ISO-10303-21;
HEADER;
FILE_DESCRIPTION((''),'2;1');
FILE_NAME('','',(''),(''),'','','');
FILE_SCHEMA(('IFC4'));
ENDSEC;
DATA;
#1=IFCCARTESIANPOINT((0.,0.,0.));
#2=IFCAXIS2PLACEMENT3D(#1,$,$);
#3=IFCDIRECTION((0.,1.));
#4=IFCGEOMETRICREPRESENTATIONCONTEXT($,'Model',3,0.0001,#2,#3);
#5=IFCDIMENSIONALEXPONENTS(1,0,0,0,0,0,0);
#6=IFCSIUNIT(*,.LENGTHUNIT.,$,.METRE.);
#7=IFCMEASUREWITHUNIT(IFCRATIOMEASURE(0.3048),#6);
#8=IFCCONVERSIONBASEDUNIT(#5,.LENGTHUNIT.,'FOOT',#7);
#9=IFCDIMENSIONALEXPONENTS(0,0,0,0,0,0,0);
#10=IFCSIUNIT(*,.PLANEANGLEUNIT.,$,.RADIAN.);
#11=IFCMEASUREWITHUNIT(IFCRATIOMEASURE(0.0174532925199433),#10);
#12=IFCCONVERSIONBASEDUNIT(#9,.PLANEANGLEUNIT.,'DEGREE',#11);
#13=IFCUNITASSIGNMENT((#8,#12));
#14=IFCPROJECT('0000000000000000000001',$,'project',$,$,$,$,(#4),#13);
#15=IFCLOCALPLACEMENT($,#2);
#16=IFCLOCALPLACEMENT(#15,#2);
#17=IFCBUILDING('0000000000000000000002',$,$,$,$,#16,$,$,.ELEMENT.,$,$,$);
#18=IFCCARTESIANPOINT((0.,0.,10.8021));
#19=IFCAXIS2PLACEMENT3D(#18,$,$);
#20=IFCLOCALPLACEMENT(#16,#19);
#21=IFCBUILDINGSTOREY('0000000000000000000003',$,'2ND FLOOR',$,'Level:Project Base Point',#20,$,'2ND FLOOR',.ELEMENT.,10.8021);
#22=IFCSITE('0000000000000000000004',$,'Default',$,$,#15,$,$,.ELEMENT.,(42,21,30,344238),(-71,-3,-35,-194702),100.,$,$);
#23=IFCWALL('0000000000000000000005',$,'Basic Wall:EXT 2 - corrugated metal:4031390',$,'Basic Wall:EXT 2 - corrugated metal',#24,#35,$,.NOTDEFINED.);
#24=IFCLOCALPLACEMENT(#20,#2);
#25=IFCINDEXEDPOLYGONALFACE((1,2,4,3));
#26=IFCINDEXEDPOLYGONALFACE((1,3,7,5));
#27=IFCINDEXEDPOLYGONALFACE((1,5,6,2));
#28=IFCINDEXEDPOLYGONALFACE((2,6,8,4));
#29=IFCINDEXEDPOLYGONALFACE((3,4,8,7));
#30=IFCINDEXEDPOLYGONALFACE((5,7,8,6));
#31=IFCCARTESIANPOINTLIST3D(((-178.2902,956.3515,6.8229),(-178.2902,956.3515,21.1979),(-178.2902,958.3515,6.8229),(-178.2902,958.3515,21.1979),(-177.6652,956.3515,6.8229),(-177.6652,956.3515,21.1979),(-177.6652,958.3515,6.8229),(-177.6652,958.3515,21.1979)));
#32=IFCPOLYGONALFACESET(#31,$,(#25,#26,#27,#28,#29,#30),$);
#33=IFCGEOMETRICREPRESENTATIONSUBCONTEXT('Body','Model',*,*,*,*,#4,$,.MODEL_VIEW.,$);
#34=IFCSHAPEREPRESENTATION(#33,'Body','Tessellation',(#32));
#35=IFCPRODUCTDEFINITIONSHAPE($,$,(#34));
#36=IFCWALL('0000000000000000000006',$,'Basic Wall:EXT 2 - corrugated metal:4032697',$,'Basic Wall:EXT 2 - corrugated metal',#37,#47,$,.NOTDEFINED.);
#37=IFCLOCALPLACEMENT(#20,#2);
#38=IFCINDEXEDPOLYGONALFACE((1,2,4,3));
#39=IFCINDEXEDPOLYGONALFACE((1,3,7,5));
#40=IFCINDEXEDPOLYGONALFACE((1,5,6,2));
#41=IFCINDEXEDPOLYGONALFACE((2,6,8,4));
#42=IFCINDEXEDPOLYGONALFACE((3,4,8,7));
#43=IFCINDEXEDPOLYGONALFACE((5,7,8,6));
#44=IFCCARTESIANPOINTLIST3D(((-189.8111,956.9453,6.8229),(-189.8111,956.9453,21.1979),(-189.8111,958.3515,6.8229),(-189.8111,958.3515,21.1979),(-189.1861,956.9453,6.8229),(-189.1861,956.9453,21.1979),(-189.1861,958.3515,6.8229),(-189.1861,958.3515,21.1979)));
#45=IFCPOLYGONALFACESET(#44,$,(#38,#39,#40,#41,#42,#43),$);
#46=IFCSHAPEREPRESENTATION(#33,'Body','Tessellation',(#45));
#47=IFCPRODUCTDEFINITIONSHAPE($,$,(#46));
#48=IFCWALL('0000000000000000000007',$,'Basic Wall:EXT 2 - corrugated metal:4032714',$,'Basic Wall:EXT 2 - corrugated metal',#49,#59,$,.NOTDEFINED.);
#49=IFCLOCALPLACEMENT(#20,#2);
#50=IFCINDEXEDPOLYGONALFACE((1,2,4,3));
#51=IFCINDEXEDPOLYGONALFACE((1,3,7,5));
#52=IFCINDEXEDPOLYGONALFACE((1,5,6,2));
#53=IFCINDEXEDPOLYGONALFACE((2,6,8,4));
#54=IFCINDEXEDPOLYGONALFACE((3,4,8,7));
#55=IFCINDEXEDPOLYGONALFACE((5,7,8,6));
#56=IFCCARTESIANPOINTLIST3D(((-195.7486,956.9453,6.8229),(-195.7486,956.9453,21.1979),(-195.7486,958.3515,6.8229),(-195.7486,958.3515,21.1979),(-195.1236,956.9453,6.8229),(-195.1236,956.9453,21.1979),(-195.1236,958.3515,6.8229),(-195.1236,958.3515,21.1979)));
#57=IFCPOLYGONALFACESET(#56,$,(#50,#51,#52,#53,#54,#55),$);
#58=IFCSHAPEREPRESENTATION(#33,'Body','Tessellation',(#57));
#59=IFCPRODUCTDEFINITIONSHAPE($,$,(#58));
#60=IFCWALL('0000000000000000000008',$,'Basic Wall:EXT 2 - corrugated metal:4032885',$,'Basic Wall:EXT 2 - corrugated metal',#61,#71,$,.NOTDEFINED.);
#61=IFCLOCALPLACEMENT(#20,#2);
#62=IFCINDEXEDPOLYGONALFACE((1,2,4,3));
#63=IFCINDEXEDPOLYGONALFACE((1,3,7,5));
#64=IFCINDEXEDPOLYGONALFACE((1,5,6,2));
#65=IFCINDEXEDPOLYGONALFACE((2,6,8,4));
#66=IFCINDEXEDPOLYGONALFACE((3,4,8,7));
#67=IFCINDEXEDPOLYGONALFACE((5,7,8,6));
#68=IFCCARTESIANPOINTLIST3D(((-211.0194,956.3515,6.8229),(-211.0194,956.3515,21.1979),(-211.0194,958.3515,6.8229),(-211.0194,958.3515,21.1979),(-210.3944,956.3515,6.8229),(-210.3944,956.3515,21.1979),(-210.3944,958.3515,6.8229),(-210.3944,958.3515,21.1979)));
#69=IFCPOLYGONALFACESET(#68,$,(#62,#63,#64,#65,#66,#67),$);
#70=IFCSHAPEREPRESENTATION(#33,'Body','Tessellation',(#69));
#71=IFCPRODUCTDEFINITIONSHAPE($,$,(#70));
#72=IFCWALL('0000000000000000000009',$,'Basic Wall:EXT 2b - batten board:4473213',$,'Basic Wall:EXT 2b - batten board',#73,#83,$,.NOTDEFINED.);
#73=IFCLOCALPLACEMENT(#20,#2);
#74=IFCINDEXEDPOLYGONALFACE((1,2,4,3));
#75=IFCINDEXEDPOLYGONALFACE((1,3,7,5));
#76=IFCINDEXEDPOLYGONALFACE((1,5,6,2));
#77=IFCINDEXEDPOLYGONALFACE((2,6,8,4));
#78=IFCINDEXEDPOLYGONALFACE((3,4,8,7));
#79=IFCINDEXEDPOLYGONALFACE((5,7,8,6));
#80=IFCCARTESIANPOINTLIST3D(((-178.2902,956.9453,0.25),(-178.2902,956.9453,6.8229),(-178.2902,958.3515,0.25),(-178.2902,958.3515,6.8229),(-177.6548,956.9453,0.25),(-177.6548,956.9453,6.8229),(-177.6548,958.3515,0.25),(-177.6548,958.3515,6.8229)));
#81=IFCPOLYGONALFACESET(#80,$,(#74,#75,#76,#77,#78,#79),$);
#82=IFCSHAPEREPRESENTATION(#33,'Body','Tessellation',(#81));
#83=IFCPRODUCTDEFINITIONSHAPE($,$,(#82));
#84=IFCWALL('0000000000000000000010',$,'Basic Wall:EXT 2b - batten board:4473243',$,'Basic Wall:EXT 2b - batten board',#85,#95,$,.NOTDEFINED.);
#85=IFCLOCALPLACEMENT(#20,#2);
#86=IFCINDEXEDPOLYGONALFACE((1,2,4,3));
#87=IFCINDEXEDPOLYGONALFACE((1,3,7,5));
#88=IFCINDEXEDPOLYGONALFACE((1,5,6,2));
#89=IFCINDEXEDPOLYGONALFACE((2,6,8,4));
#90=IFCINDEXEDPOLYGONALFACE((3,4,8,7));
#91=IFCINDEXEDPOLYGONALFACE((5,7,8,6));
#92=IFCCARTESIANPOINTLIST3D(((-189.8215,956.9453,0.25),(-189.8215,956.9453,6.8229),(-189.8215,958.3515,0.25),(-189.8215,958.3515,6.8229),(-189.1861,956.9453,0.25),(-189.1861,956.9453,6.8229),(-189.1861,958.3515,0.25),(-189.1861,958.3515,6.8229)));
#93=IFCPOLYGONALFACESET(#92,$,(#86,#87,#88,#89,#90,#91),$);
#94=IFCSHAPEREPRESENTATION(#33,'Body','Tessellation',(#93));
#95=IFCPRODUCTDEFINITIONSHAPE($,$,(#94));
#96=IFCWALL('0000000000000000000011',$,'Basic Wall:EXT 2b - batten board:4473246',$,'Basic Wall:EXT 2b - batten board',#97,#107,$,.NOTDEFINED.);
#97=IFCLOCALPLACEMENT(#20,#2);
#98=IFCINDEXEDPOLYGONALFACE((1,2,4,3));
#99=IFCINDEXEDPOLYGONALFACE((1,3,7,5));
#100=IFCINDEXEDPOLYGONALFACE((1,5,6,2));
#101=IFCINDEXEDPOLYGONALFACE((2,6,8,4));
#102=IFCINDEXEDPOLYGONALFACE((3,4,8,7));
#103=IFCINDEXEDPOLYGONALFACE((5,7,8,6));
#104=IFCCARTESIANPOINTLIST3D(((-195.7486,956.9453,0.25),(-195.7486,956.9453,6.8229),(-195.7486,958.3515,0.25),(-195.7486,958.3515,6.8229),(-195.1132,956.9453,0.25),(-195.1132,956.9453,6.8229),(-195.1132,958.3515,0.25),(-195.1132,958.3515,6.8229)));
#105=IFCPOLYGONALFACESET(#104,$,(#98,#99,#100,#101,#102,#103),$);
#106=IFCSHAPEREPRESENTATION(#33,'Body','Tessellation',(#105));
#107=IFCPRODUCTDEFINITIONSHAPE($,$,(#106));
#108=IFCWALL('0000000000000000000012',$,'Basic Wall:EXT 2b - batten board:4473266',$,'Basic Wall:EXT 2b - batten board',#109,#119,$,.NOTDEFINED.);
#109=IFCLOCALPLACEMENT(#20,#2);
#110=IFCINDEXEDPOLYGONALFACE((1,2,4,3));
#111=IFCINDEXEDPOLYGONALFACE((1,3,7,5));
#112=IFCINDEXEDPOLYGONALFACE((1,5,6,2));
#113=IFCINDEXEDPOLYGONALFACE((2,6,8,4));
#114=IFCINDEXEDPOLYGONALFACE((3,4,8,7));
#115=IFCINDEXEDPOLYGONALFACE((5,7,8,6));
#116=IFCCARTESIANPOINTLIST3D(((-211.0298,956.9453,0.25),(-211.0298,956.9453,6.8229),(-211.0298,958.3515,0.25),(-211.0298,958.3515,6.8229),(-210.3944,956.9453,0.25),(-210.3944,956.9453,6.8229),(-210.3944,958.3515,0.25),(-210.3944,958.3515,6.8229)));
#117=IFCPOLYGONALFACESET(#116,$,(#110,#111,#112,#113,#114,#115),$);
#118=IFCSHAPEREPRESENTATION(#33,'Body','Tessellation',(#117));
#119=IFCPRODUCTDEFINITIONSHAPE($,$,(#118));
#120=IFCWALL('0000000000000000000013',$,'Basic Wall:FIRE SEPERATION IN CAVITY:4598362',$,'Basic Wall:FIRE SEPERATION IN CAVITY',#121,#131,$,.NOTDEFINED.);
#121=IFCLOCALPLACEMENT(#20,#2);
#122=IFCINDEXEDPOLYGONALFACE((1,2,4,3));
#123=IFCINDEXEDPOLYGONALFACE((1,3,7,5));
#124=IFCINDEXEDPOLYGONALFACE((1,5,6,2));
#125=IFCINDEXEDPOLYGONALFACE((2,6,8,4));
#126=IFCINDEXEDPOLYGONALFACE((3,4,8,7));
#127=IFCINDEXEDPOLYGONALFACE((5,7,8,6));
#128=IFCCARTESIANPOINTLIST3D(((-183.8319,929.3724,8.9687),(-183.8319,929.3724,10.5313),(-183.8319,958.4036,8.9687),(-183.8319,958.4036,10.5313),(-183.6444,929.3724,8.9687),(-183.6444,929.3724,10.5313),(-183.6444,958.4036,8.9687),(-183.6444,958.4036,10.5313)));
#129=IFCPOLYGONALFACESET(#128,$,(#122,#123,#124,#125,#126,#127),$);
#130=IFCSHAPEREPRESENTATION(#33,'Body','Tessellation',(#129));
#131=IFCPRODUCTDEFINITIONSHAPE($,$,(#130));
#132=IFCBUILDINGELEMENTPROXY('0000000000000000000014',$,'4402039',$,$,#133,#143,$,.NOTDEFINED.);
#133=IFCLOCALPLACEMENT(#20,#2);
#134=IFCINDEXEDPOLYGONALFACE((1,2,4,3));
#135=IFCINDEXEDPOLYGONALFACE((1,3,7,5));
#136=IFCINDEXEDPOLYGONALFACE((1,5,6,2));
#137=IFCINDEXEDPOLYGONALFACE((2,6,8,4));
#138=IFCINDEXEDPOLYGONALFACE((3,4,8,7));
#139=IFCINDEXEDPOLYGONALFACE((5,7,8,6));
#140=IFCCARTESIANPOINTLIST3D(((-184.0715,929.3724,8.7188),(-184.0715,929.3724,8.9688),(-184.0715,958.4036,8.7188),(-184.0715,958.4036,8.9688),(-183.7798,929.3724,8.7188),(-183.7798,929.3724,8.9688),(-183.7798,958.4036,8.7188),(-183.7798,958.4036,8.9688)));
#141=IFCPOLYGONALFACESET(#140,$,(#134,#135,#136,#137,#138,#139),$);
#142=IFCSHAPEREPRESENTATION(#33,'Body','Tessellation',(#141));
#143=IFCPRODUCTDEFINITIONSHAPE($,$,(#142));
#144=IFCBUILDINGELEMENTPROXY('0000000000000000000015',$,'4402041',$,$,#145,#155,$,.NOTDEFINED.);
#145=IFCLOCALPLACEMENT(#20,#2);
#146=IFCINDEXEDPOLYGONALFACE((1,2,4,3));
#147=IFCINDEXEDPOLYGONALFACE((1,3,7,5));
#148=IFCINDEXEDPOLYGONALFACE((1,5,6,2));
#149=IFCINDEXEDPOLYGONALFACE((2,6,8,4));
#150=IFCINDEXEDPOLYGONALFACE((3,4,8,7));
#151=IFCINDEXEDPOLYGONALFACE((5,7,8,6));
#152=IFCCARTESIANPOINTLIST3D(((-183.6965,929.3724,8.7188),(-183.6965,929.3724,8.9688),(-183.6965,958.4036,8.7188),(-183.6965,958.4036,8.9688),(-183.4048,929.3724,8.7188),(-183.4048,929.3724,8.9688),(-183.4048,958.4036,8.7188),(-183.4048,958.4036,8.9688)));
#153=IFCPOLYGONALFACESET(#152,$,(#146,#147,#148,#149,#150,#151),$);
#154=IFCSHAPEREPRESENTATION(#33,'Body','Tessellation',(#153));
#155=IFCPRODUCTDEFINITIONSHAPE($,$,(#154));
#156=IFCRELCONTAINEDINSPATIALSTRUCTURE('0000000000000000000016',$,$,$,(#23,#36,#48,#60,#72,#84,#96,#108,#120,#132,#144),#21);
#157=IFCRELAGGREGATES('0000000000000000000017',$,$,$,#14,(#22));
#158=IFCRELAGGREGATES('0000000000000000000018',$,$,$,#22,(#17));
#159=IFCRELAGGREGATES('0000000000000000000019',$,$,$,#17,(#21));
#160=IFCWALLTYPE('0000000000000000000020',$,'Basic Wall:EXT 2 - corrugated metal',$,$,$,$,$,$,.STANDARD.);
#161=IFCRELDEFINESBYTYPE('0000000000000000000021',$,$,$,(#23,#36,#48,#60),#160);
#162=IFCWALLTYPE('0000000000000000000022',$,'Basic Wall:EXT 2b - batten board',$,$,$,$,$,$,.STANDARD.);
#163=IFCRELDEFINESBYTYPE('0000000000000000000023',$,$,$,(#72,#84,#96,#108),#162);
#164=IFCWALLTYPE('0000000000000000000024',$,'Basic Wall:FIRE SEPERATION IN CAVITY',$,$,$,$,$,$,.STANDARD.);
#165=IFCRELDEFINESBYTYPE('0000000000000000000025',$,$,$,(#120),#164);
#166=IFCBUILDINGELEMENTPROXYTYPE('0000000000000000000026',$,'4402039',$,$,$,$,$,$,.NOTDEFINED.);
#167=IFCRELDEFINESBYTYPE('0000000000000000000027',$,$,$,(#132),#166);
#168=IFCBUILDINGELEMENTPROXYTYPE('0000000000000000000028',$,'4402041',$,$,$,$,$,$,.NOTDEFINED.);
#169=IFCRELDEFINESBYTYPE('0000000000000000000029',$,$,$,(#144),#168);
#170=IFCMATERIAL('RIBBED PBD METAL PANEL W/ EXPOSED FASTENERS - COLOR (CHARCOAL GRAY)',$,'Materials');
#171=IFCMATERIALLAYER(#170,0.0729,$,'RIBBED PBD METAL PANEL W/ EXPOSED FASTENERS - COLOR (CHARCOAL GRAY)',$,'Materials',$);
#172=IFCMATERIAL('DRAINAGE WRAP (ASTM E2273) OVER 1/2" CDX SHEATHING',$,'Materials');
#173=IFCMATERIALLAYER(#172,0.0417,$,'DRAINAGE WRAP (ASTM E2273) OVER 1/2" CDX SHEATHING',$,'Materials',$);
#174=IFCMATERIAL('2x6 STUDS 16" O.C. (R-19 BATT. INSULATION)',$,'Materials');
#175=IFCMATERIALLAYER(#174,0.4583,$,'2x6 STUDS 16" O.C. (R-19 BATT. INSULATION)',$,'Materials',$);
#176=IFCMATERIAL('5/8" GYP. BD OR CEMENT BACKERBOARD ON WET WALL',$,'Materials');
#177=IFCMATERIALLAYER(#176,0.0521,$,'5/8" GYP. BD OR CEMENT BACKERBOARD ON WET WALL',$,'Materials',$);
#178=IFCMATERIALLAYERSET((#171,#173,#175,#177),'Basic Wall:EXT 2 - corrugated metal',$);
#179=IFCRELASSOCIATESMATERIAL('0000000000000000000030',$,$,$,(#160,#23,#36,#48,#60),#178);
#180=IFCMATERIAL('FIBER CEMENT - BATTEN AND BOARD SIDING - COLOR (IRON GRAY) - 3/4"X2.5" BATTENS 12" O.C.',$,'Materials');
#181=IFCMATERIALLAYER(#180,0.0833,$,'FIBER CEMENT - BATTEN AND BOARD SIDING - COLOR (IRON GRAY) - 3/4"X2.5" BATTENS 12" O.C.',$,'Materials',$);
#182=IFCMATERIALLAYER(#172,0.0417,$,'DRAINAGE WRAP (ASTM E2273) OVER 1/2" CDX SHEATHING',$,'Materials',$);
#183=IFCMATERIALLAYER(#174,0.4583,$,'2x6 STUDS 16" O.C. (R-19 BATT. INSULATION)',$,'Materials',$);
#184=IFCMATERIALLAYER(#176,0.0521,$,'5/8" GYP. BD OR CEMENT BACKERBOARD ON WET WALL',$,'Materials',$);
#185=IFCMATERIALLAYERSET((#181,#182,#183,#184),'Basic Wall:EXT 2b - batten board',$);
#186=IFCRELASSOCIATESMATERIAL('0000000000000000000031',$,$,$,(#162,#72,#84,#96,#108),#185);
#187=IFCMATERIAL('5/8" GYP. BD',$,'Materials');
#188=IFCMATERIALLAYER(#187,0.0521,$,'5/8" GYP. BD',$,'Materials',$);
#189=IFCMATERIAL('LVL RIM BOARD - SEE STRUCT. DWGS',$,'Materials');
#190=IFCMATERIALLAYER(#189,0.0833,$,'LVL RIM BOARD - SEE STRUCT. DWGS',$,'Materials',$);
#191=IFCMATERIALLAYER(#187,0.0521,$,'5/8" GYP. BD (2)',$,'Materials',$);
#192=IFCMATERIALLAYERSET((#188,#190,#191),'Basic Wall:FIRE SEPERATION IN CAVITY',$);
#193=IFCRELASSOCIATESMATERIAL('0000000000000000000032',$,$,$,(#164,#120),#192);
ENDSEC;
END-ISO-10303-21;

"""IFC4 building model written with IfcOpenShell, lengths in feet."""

from ifc_helpers import new_model, entity, si_unit, converted_unit, direction, frame, frame_2d, origin, origin_2d_with_axis, place, context, subcontext, project, spatial, rectangle, extrude, material, layer, layer_set, layer_usage, type_object, element, save


model = new_model("IFC4")

# Units and contexts
model_context = context("Model", 3, precision=0.0001, world=origin(), true_north=direction((0.0, 1.0)))
body_context = subcontext(model_context, "Body", "Model", "MODEL_VIEW")
ifc_project = project(units=[converted_unit("LENGTHUNIT", "FOOT", entity("IfcRatioMeasure", 0.3048), si_unit("LENGTHUNIT", "METRE"), dimensions=[1, 0, 0, 0, 0, 0, 0]), converted_unit("PLANEANGLEUNIT", "DEGREE", entity("IfcRatioMeasure", 0.0174532925199433), si_unit("PLANEANGLEUNIT", "RADIAN"), dimensions=[0, 0, 0, 0, 0, 0, 0])], contexts=[model_context])

# Site, building, storey
site_placement = place(None, origin())
site = spatial("IfcSite", under=ifc_project, at=site_placement, Name="Default", CompositionType="ELEMENT", RefLatitude=(42, 21, 30, 344238), RefLongitude=(-71, -3, -35, -194702), RefElevation=100.0)
building_placement = place(site_placement, origin())
building = spatial("IfcBuilding", under=site, at=building_placement, CompositionType="ELEMENT")
storey_placement = place(building_placement, frame((0.0, 0.0, 10.8021)))
storey = spatial("IfcBuildingStorey", under=building, at=storey_placement, Name="2ND FLOOR", ObjectType="Level:Project Base Point", LongName="2ND FLOOR", CompositionType="ELEMENT", Elevation=10.8021)

# Walls
ifc_material_1 = material(Name="RIBBED PBD METAL PANEL W/ EXPOSED FASTENERS - COLOR (CHARCOAL GRAY)", Category="Materials")
ifc_layer_1 = layer(ifc_material_1, 0.0729, Name="RIBBED PBD METAL PANEL W/ EXPOSED FASTENERS - COLOR (CHARCOAL GRAY)", Category="Materials")
ifc_material_2 = material(Name="DRAINAGE WRAP (ASTM E2273) OVER 1/2\" CDX SHEATHING", Category="Materials")
ifc_layer_2 = layer(ifc_material_2, 0.0417, Name="DRAINAGE WRAP (ASTM E2273) OVER 1/2\" CDX SHEATHING", Category="Materials")
ifc_material_3 = material(Name="2x6 STUDS 16\" O.C. (R-19 BATT. INSULATION)", Category="Materials")
ifc_layer_3 = layer(ifc_material_3, 0.4583, Name="2x6 STUDS 16\" O.C. (R-19 BATT. INSULATION)", Category="Materials")
ifc_material_4 = material(Name="5/8\" GYP. BD OR CEMENT BACKERBOARD ON WET WALL", Category="Materials")
ifc_layer_4 = layer(ifc_material_4, 0.0521, Name="5/8\" GYP. BD OR CEMENT BACKERBOARD ON WET WALL", Category="Materials")
ifc_layer_set_1 = layer_set([ifc_layer_1, ifc_layer_2, ifc_layer_3, ifc_layer_4], Name="Basic Wall:EXT 2 - corrugated metal")
ifc_layer_usage_1 = layer_usage(ifc_layer_set_1, "AXIS2", "NEGATIVE", 0.3125)
wall_type_1 = type_object("IfcWallType", Name="Basic Wall:EXT 2 - corrugated metal", PredefinedType="STANDARD", material=ifc_layer_set_1)
wall_1_placement = place(storey_placement, frame((-177.9777, 958.3515, 6.8229), z_axis=(0.0, 0.0, 1.0), x_axis=(0.0, -1.0, 0.0)))
element("IfcWall", 1, at=wall_1_placement, inside=storey, type_object=wall_type_1, material=ifc_layer_usage_1, Name="Basic Wall:EXT 2 - corrugated metal:4031390", ObjectType="Basic Wall:EXT 2 - corrugated metal", PredefinedType="NOTDEFINED", context=body_context, shape_type="SweptSolid", body=[
    extrude(rectangle(XDim=2.0, YDim=0.625, at=frame_2d((1.0, 0.0), x_axis=(-1.0, 0.0))), origin(), (0.0, 0.0, 1.0), 14.375),
])
ifc_layer_usage_2 = layer_usage(ifc_layer_set_1, "AXIS2", "POSITIVE", -0.3125)
wall_2_placement = place(storey_placement, frame((-189.4986, 958.3515, 6.8229), z_axis=(0.0, 0.0, 1.0), x_axis=(0.0, -1.0, 0.0)))
element("IfcWall", 2, at=wall_2_placement, inside=storey, type_object=wall_type_1, material=ifc_layer_usage_2, Name="Basic Wall:EXT 2 - corrugated metal:4032697", ObjectType="Basic Wall:EXT 2 - corrugated metal", PredefinedType="NOTDEFINED", context=body_context, shape_type="SweptSolid", body=[
    extrude(rectangle(XDim=1.4063, YDim=0.625, at=frame_2d((0.7031, 0.0), x_axis=(-1.0, 0.0))), origin(), (0.0, 0.0, 1.0), 14.375),
])
ifc_layer_usage_3 = layer_usage(ifc_layer_set_1, "AXIS2", "NEGATIVE", 0.3125)
wall_3_placement = place(storey_placement, frame((-195.4361, 958.3515, 6.8229), z_axis=(0.0, 0.0, 1.0), x_axis=(0.0, -1.0, 0.0)))
element("IfcWall", 3, at=wall_3_placement, inside=storey, type_object=wall_type_1, material=ifc_layer_usage_3, Name="Basic Wall:EXT 2 - corrugated metal:4032714", ObjectType="Basic Wall:EXT 2 - corrugated metal", PredefinedType="NOTDEFINED", context=body_context, shape_type="SweptSolid", body=[
    extrude(rectangle(XDim=1.4062, YDim=0.625, at=frame_2d((0.7031, 0.0), x_axis=(-1.0, 0.0))), origin(), (0.0, 0.0, 1.0), 14.375),
])
ifc_layer_usage_4 = layer_usage(ifc_layer_set_1, "AXIS2", "POSITIVE", -0.3125)
wall_4_placement = place(storey_placement, frame((-210.7069, 958.3515, 6.8229), z_axis=(0.0, 0.0, 1.0), x_axis=(0.0, -1.0, 0.0)))
element("IfcWall", 4, at=wall_4_placement, inside=storey, type_object=wall_type_1, material=ifc_layer_usage_4, Name="Basic Wall:EXT 2 - corrugated metal:4032885", ObjectType="Basic Wall:EXT 2 - corrugated metal", PredefinedType="NOTDEFINED", context=body_context, shape_type="SweptSolid", body=[
    extrude(rectangle(XDim=2.0, YDim=0.625, at=frame_2d((1.0, 0.0), x_axis=(-1.0, 0.0))), origin(), (0.0, 0.0, 1.0), 14.375),
])
ifc_material_5 = material(Name="FIBER CEMENT - BATTEN AND BOARD SIDING - COLOR (IRON GRAY) - 3/4\"X2.5\" BATTENS 12\" O.C.", Category="Materials")
ifc_layer_5 = layer(ifc_material_5, 0.0833, Name="FIBER CEMENT - BATTEN AND BOARD SIDING - COLOR (IRON GRAY) - 3/4\"X2.5\" BATTENS 12\" O.C.", Category="Materials")
ifc_layer_6 = layer(ifc_material_2, 0.0417, Name="DRAINAGE WRAP (ASTM E2273) OVER 1/2\" CDX SHEATHING", Category="Materials")
ifc_layer_7 = layer(ifc_material_3, 0.4583, Name="2x6 STUDS 16\" O.C. (R-19 BATT. INSULATION)", Category="Materials")
ifc_layer_8 = layer(ifc_material_4, 0.0521, Name="5/8\" GYP. BD OR CEMENT BACKERBOARD ON WET WALL", Category="Materials")
ifc_layer_set_2 = layer_set([ifc_layer_5, ifc_layer_6, ifc_layer_7, ifc_layer_8], Name="Basic Wall:EXT 2b - batten board")
ifc_layer_usage_5 = layer_usage(ifc_layer_set_2, "AXIS2", "NEGATIVE", 0.3177)
wall_type_2 = type_object("IfcWallType", Name="Basic Wall:EXT 2b - batten board", PredefinedType="STANDARD", material=ifc_layer_set_2)
wall_5_placement = place(storey_placement, frame((-177.9725, 958.3515, 0.25), z_axis=(0.0, 0.0, 1.0), x_axis=(0.0, -1.0, 0.0)))
element("IfcWall", 5, at=wall_5_placement, inside=storey, type_object=wall_type_2, material=ifc_layer_usage_5, Name="Basic Wall:EXT 2b - batten board:4473213", ObjectType="Basic Wall:EXT 2b - batten board", PredefinedType="NOTDEFINED", context=body_context, shape_type="SweptSolid", body=[
    extrude(rectangle(XDim=1.4063, YDim=0.6354, at=frame_2d((0.7031, 0.0), x_axis=(-1.0, 0.0))), origin(), (0.0, 0.0, 1.0), 6.5729),
])
ifc_layer_usage_6 = layer_usage(ifc_layer_set_2, "AXIS2", "POSITIVE", -0.3177)
wall_6_placement = place(storey_placement, frame((-189.5038, 958.3515, 0.25), z_axis=(0.0, 0.0, 1.0), x_axis=(0.0, -1.0, 0.0)))
element("IfcWall", 6, at=wall_6_placement, inside=storey, type_object=wall_type_2, material=ifc_layer_usage_6, Name="Basic Wall:EXT 2b - batten board:4473243", ObjectType="Basic Wall:EXT 2b - batten board", PredefinedType="NOTDEFINED", context=body_context, shape_type="SweptSolid", body=[
    extrude(rectangle(XDim=1.4063, YDim=0.6354, at=frame_2d((0.7031, 0.0), x_axis=(-1.0, 0.0))), origin(), (0.0, 0.0, 1.0), 6.5729),
])
ifc_layer_usage_7 = layer_usage(ifc_layer_set_2, "AXIS2", "NEGATIVE", 0.3177)
wall_7_placement = place(storey_placement, frame((-195.4309, 958.3515, 0.25), z_axis=(0.0, 0.0, 1.0), x_axis=(0.0, -1.0, 0.0)))
element("IfcWall", 7, at=wall_7_placement, inside=storey, type_object=wall_type_2, material=ifc_layer_usage_7, Name="Basic Wall:EXT 2b - batten board:4473246", ObjectType="Basic Wall:EXT 2b - batten board", PredefinedType="NOTDEFINED", context=body_context, shape_type="SweptSolid", body=[
    extrude(rectangle(XDim=1.4062, YDim=0.6354, at=frame_2d((0.7031, 0.0), x_axis=(-1.0, 0.0))), origin(), (0.0, 0.0, 1.0), 6.5729),
])
ifc_layer_usage_8 = layer_usage(ifc_layer_set_2, "AXIS2", "POSITIVE", -0.3177)
wall_8_placement = place(storey_placement, frame((-210.7121, 958.3515, 0.25), z_axis=(0.0, 0.0, 1.0), x_axis=(0.0, -1.0, 0.0)))
element("IfcWall", 8, at=wall_8_placement, inside=storey, type_object=wall_type_2, material=ifc_layer_usage_8, Name="Basic Wall:EXT 2b - batten board:4473266", ObjectType="Basic Wall:EXT 2b - batten board", PredefinedType="NOTDEFINED", context=body_context, shape_type="SweptSolid", body=[
    extrude(rectangle(XDim=1.4062, YDim=0.6354, at=frame_2d((0.7031, 0.0), x_axis=(-1.0, 0.0))), origin(), (0.0, 0.0, 1.0), 6.5729),
])
ifc_material_6 = material(Name="5/8\" GYP. BD", Category="Materials")
ifc_layer_9 = layer(ifc_material_6, 0.0521, Name="5/8\" GYP. BD", Category="Materials")
ifc_material_7 = material(Name="LVL RIM BOARD - SEE STRUCT. DWGS", Category="Materials")
ifc_layer_10 = layer(ifc_material_7, 0.0833, Name="LVL RIM BOARD - SEE STRUCT. DWGS", Category="Materials")
ifc_layer_11 = layer(ifc_material_6, 0.0521, Name="5/8\" GYP. BD (2)", Category="Materials")
ifc_layer_set_3 = layer_set([ifc_layer_9, ifc_layer_10, ifc_layer_11], Name="Basic Wall:FIRE SEPERATION IN CAVITY")
ifc_layer_usage_9 = layer_usage(ifc_layer_set_3, "AXIS2", "POSITIVE", -0.0938)
wall_type_3 = type_object("IfcWallType", Name="Basic Wall:FIRE SEPERATION IN CAVITY", PredefinedType="STANDARD", material=ifc_layer_set_3)
wall_9_placement = place(storey_placement, frame((-183.7382, 929.3724, 8.9687), z_axis=(0.0, 0.0, 1.0), x_axis=(0.0, 1.0, 0.0)))
element("IfcWall", 9, at=wall_9_placement, inside=storey, type_object=wall_type_3, material=ifc_layer_usage_9, Name="Basic Wall:FIRE SEPERATION IN CAVITY:4598362", ObjectType="Basic Wall:FIRE SEPERATION IN CAVITY", PredefinedType="NOTDEFINED", context=body_context, shape_type="SweptSolid", body=[
    extrude(rectangle(XDim=29.0313, YDim=0.1875, at=frame_2d((14.5156, 0.0), x_axis=(-1.0, 0.0))), origin(), (0.0, 0.0, 1.0), 1.5625),
])

# Building element proxies
building_element_proxy_type_1 = type_object("IfcBuildingElementProxyType", Name="4402039", PredefinedType="NOTDEFINED")
proxy_1_placement = place(storey_placement, frame((-184.0715, 929.3724, 8.7188)))
element("IfcBuildingElementProxy", 10, at=proxy_1_placement, inside=storey, type_object=building_element_proxy_type_1, Name="4402039", PredefinedType="NOTDEFINED", context=body_context, shape_type="SweptSolid", body=[
    extrude(rectangle(XDim=29.0313, YDim=0.2917, at=origin_2d_with_axis()), frame((0.1458, 14.5156, 0.0), z_axis=(0.0, 0.0, 1.0), x_axis=(0.0, 1.0, 0.0)), (0.0, 0.0, 1.0), 0.25),
])
building_element_proxy_type_2 = type_object("IfcBuildingElementProxyType", Name="4402041", PredefinedType="NOTDEFINED")
proxy_2_placement = place(storey_placement, frame((-183.6965, 929.3724, 8.7188)))
element("IfcBuildingElementProxy", 11, at=proxy_2_placement, inside=storey, type_object=building_element_proxy_type_2, Name="4402041", PredefinedType="NOTDEFINED", context=body_context, shape_type="SweptSolid", body=[
    extrude(rectangle(XDim=29.0313, YDim=0.2917, at=origin_2d_with_axis()), frame((0.1458, 14.5156, 0.0), z_axis=(0.0, 0.0, 1.0), x_axis=(0.0, 1.0, 0.0)), (0.0, 0.0, 1.0), 0.25),
])

save(model, "model.ifc")
